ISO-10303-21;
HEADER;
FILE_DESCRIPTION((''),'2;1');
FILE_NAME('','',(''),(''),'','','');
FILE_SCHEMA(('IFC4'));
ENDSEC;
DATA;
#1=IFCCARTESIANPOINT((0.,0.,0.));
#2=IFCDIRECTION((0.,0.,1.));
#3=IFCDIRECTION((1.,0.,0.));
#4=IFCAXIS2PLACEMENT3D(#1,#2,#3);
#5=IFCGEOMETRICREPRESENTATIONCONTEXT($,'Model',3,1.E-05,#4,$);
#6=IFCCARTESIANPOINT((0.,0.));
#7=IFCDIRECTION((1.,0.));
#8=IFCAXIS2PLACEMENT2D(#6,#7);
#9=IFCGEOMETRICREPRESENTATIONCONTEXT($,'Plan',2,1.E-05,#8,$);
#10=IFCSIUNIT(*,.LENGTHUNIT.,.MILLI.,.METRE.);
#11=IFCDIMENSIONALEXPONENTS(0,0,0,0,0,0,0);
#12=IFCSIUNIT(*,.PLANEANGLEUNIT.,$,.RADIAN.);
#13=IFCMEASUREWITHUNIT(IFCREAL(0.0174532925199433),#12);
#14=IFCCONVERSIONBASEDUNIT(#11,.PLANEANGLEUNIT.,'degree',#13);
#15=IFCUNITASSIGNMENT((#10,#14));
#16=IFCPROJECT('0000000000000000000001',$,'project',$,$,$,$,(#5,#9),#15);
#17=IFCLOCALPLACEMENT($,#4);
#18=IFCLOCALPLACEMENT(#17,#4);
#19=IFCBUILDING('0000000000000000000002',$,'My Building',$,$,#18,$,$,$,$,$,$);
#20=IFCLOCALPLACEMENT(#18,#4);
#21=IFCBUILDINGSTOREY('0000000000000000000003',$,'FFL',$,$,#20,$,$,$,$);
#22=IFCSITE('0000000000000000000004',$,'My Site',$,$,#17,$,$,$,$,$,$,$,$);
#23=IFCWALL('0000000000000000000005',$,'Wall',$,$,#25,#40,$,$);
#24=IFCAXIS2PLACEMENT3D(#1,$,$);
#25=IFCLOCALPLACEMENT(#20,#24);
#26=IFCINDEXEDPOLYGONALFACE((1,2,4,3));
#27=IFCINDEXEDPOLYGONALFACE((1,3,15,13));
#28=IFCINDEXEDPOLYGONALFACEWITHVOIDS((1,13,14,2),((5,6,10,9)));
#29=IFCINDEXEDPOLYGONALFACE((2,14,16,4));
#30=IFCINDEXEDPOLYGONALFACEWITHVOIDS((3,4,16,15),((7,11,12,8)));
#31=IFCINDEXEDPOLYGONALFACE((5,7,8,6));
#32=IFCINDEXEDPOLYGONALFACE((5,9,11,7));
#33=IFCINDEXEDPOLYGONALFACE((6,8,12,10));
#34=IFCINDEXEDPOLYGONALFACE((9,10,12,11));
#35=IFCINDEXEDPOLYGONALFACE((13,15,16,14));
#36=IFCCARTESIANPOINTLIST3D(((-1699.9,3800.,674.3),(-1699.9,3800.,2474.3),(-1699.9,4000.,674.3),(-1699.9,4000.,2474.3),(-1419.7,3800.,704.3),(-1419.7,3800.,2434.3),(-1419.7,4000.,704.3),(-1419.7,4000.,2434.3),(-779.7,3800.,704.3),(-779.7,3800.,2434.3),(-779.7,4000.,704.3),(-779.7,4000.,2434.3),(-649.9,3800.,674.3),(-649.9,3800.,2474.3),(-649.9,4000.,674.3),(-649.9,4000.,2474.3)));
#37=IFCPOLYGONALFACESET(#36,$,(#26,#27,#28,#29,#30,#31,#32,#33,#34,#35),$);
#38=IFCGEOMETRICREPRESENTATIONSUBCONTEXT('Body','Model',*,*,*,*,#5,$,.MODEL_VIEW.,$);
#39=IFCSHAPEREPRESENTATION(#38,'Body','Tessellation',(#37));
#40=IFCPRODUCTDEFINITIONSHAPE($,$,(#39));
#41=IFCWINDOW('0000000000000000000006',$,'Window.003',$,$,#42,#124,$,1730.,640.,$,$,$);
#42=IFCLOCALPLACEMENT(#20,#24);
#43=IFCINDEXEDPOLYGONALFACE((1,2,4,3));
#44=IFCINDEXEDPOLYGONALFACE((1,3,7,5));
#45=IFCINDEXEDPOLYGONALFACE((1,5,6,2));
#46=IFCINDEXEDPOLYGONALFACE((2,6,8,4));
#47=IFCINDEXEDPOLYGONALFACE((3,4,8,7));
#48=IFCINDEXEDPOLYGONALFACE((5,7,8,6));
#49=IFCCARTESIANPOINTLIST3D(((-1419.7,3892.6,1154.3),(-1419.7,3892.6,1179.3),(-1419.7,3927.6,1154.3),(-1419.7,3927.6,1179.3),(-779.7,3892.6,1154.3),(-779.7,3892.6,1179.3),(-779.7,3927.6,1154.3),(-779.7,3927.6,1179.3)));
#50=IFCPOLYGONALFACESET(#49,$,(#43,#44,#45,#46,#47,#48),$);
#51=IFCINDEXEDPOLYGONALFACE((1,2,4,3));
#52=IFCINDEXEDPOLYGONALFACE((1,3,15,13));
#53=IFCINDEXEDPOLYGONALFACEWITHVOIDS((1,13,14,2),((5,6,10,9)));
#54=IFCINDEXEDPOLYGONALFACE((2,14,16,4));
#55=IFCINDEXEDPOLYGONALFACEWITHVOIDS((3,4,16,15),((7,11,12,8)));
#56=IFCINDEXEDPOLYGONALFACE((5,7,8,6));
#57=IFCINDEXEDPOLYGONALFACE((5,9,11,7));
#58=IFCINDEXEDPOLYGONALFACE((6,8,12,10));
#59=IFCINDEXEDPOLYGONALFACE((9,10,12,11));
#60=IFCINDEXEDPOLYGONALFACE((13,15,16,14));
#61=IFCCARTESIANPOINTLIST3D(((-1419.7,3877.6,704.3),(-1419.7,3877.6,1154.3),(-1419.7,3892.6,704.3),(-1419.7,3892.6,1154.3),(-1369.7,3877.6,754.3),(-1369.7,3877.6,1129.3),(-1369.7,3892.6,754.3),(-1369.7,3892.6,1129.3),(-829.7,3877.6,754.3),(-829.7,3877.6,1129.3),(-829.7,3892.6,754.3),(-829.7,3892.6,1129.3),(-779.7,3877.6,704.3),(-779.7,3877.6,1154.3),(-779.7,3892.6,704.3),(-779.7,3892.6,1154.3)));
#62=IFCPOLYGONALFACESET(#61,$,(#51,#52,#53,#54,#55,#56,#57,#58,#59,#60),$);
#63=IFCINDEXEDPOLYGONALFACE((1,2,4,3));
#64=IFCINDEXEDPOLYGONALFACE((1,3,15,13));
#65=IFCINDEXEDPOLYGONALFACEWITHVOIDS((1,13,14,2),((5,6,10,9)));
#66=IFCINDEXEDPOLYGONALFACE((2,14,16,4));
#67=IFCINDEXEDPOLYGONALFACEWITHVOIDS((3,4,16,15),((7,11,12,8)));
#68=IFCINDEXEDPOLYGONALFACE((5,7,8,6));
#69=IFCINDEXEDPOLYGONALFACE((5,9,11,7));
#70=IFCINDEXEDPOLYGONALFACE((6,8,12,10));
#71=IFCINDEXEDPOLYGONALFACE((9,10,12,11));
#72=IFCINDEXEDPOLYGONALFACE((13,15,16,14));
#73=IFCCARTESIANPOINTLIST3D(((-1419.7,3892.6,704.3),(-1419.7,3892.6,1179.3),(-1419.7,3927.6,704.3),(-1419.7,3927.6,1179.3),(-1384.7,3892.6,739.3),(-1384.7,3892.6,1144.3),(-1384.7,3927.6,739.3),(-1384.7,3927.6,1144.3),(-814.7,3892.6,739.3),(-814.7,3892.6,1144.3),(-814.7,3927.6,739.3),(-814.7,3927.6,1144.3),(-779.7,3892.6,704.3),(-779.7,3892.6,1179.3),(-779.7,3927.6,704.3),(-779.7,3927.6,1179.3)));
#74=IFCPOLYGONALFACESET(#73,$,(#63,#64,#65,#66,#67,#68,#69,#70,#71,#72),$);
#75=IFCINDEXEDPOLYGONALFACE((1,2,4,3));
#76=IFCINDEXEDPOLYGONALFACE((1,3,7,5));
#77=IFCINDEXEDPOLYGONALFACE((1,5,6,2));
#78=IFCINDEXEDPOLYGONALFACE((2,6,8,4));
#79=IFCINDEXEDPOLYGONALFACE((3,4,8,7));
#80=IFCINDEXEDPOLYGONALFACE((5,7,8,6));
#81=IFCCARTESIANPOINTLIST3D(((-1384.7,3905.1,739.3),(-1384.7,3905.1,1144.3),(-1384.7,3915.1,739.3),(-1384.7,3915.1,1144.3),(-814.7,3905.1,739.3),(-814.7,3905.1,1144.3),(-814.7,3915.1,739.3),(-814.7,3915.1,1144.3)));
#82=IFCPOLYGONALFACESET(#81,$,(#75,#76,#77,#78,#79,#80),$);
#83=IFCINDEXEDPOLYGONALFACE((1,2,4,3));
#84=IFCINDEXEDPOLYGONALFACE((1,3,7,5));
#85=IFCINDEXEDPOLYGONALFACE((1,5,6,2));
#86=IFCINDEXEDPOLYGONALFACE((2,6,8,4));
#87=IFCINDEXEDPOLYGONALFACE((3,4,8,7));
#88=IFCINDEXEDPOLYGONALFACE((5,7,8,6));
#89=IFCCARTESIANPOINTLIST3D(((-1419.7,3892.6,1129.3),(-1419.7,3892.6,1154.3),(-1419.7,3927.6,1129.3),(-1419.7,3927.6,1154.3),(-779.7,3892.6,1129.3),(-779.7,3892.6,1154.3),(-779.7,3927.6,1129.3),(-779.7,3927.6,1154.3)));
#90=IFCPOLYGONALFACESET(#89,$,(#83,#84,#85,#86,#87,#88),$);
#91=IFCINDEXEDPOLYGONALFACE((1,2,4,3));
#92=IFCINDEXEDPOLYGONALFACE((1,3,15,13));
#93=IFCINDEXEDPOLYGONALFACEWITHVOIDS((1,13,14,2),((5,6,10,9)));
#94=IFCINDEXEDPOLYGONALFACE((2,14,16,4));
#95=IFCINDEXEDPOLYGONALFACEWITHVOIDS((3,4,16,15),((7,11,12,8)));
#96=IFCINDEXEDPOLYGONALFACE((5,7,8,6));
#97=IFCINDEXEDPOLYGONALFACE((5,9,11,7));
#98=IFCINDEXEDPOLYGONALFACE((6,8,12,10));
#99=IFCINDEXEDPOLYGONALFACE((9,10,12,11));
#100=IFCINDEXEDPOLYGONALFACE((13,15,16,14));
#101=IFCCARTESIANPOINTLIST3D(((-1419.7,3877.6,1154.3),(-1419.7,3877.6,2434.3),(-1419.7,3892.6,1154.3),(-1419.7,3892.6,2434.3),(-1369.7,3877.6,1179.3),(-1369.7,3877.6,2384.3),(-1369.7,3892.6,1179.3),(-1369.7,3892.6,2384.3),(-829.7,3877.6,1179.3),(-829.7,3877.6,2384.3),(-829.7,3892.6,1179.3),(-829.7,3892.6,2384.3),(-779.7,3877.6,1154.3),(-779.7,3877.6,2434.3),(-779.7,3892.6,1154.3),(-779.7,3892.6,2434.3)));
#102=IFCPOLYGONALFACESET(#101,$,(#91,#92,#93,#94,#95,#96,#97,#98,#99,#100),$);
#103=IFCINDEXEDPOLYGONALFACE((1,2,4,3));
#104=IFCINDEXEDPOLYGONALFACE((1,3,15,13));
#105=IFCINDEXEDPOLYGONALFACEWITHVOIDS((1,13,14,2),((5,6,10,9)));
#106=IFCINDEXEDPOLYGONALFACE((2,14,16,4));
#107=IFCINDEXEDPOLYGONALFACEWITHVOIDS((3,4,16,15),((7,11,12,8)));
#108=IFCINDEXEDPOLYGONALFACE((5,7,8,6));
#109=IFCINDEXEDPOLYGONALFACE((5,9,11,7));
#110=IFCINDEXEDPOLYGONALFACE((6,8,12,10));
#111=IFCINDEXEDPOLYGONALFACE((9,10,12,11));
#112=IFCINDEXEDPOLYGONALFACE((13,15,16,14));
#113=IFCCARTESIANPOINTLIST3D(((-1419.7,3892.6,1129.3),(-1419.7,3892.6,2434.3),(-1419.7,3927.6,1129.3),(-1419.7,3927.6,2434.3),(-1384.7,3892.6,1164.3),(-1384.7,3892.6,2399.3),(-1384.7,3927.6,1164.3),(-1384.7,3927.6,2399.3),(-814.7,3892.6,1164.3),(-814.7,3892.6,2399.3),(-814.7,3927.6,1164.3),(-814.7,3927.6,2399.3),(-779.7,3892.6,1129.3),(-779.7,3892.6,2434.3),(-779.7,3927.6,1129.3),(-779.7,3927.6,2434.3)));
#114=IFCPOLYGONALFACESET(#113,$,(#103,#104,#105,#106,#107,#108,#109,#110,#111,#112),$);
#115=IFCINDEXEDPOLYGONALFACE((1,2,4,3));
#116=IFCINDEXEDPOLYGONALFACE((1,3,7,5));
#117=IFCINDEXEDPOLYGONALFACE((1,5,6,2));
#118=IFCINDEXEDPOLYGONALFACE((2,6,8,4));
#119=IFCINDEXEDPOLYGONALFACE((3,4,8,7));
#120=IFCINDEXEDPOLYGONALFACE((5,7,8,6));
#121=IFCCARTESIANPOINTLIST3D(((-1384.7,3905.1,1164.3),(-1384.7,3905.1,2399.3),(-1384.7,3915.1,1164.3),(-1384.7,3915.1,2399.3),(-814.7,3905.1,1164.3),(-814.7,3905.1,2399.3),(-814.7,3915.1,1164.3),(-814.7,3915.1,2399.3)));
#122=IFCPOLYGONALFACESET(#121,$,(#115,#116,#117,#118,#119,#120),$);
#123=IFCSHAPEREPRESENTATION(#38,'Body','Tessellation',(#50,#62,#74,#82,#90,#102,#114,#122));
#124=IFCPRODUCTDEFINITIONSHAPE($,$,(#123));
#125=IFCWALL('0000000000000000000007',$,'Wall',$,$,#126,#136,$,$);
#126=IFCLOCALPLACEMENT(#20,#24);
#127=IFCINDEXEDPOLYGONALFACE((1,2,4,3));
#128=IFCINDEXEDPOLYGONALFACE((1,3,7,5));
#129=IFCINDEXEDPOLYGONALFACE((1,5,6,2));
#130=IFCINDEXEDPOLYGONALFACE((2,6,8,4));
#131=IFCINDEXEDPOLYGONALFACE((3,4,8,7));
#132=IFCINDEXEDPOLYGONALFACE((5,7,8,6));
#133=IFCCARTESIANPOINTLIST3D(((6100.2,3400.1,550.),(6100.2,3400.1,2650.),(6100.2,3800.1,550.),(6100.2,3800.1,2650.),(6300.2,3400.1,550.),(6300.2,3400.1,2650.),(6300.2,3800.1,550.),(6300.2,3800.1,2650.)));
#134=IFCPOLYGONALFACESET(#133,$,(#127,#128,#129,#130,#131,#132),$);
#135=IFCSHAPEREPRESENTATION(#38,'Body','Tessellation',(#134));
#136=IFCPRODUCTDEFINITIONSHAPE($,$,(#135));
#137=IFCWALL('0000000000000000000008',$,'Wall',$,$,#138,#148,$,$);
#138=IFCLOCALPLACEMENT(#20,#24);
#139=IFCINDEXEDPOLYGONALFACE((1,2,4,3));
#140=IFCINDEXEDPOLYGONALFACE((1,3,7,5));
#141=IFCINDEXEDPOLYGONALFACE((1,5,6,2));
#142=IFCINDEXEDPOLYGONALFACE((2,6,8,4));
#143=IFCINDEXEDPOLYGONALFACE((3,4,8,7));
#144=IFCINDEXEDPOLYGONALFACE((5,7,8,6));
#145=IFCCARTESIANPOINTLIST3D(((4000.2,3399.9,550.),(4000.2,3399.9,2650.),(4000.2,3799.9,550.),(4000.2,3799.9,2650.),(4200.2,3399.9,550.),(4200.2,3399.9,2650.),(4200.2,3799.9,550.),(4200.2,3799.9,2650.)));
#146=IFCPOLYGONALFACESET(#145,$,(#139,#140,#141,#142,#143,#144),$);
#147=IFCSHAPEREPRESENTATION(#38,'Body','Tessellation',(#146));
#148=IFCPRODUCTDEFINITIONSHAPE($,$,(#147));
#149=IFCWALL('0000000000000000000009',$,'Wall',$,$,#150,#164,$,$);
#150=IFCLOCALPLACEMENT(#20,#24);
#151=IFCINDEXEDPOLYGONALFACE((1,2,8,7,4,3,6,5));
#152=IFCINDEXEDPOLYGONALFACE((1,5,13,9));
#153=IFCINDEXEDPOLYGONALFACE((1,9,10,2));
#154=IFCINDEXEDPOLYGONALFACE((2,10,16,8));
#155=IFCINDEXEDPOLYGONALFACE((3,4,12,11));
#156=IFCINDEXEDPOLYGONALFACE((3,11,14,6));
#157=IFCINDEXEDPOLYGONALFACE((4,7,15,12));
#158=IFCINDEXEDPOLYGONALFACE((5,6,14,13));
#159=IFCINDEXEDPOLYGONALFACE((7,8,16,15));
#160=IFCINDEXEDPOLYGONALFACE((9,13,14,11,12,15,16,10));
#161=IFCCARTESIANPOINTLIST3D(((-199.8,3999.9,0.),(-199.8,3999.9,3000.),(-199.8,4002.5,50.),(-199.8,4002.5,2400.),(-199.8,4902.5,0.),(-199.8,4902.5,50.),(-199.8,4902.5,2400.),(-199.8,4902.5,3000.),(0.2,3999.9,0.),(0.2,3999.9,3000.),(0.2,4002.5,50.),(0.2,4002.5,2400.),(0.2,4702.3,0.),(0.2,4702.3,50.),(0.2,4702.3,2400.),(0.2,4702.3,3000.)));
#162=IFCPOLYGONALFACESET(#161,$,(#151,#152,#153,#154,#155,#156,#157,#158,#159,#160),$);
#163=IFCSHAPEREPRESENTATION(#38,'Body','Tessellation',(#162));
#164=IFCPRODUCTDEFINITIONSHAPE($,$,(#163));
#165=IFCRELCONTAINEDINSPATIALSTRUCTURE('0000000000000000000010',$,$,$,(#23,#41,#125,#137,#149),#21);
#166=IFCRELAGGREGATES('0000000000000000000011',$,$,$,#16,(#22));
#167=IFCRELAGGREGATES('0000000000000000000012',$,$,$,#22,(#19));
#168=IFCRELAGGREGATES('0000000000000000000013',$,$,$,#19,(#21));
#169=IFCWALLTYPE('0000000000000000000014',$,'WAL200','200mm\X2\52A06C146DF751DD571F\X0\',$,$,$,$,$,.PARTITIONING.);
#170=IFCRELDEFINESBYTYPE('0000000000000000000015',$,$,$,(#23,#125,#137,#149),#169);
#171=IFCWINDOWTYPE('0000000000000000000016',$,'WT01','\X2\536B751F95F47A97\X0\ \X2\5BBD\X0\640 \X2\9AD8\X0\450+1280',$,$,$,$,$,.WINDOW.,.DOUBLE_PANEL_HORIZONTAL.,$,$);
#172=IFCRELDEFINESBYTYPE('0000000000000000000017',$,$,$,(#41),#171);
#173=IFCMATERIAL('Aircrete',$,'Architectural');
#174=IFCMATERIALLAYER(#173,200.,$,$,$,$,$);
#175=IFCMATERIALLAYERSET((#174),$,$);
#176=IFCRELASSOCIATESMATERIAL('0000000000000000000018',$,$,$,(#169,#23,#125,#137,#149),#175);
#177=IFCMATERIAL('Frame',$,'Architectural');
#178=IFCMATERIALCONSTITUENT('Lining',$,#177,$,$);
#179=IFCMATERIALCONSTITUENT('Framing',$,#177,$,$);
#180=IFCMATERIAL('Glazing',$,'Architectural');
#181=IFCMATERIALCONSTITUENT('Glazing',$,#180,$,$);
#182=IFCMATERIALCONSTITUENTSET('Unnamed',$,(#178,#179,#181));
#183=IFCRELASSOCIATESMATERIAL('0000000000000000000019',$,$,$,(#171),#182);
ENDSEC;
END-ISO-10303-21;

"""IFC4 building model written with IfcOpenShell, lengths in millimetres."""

from ifc_helpers import new_model, entity, si_unit, converted_unit, frame, origin_with_axes, origin_2d_with_axis, place, context, subcontext, project, spatial, line, indexed_curve, outline, extrude, shape, source, transform, mapped, material, layer, layer_set, layer_usage, constituent, constituent_set, type_object, type_shapes, element, fill, save


model = new_model("IFC4")

# Units and contexts
model_context = context("Model", 3, precision=1e-05, world=origin_with_axes())
plan_context = context("Plan", 2, precision=1e-05, world=origin_2d_with_axis())
body_context_1 = subcontext(model_context, "Body", "Model", "MODEL_VIEW")
body_context_2 = subcontext(plan_context, "Body", "Plan", "PLAN_VIEW")
ifc_project = project(units=[si_unit("LENGTHUNIT", "METRE", prefix="MILLI"), converted_unit("PLANEANGLEUNIT", "degree", entity("IfcReal", 0.0174532925199433), si_unit("PLANEANGLEUNIT", "RADIAN"), dimensions=[0, 0, 0, 0, 0, 0, 0])], contexts=[model_context, plan_context])

# Site, building, storey
site_placement = place(None, origin_with_axes())
site = spatial("IfcSite", under=ifc_project, at=site_placement, Name="My Site")
building_placement = place(site_placement, origin_with_axes())
building = spatial("IfcBuilding", under=site, at=building_placement, Name="My Building")
storey_placement = place(building_placement, origin_with_axes())
storey = spatial("IfcBuildingStorey", under=building, at=storey_placement, Name="FFL")

# Shared definitions
ifc_material_1 = material(Name="Aircrete", Category="Architectural")

# Shared definitions
ifc_material_2 = material(Name="Frame", Category="Architectural")

# Shared definitions
ifc_layer_1 = layer(ifc_material_1, 200.0)
ifc_layer_set_1 = layer_set([ifc_layer_1])
wall_type_1 = type_object("IfcWallType", Name="WAL200", Description="200mm加气混凝土", PredefinedType="PARTITIONING", material=ifc_layer_set_1)
ifc_material_3 = material(Name="Glazing", Category="Architectural")

# Wall, opening, window
ifc_layer_usage_1 = layer_usage(ifc_layer_set_1, "AXIS2", "NEGATIVE", 0.0)
wall_1_placement = place(storey_placement, frame((-1699.9, 4000.0, 674.3), z_axis=(0.0, 0.0, 1.0), x_axis=(1.0, 0.0, 0.0)))
wall_1 = element("IfcWall", 1, at=wall_1_placement, inside=storey, type_object=wall_type_1, material=ifc_layer_usage_1, Name="Wall", context=body_context_1, shape_type="SweptSolid", body=[
    extrude(outline(indexed_curve([(0.0, -200.0), (0.0, 0.0), (1050.0, 0.0), (1050.0, -200.0)], segments=[line(1, 2, 3, 4, 1)])), origin_with_axes(), (0.0, 0.0, 1.0), 1800.0),
])
shared_shape_1 = source(origin_with_axes(), body_context_1, "Body", "SweptSolid", [
    extrude(outline(indexed_curve([(0.0, 0.0), (640.0, 0.0), (640.0, 1730.0), (0.0, 1730.0)], segments=[line(1, 2, 3, 4, 1)])), frame((0.0, -600.0, 0.0), z_axis=(0.0, -1.0, 0.0), x_axis=(1.0, 0.0, 0.0)), (0.0, 0.0, -1.0), 1200.0),
])
opening_1_placement = place(wall_1_placement, frame((280.2, -172.4, 30.0), z_axis=(0.0, 0.0, 1.0), x_axis=(1.0, 0.0, 0.0)))
opening_1 = element("IfcOpeningElement", 2, at=opening_1_placement, cuts=wall_1, PredefinedType="OPENING", context=body_context_1, shape_type="MappedRepresentation", body=[
    mapped(shared_shape_1, transform((0.0, 0.0, 0.0), x_axis=(1.0, 0.0, 0.0), y_axis=(0.0, 1.0, 0.0), z_axis=(0.0, 0.0, 1.0), scale=1.0)),
])
ifc_constituent_1 = constituent(ifc_material_2, Name="Lining")
ifc_constituent_2 = constituent(ifc_material_2, Name="Framing")
ifc_constituent_3 = constituent(ifc_material_3, Name="Glazing")
ifc_constituent_set_1 = constituent_set(constituents=[ifc_constituent_1, ifc_constituent_2, ifc_constituent_3], Name="Unnamed")
window_type_1 = type_object("IfcWindowType", Name="WT01", Description="卫生间窗 宽640 高450+1280", PartitioningType="DOUBLE_PANEL_HORIZONTAL", PredefinedType="WINDOW", material=ifc_constituent_set_1)
shared_shape_2 = source(origin_with_axes(), body_context_1, "Body", "SweptSolid", [
    extrude(outline(indexed_curve([(0.0, 450.0), (640.0, 450.0), (640.0, 475.0), (0.0, 475.0)], segments=[line(1, 2, 3, 4, 1)])), frame((0.0, 65.0, 0.0), z_axis=(0.0, -1.0, 0.0), x_axis=(1.0, 0.0, 0.0)), (0.0, 0.0, -1.0), 35.0),
    extrude(outline(indexed_curve([(0.0, 0.0), (640.0, 0.0), (640.0, 450.0), (0.0, 450.0)], segments=[line(1, 2, 3, 4, 1)]), holes=[indexed_curve([(50.0, 50.0), (590.0, 50.0), (590.0, 425.0), (50.0, 425.0)], segments=[line(1, 2, 3, 4, 1)])]), frame((0.0, 50.0, 0.0), z_axis=(0.0, -1.0, 0.0), x_axis=(1.0, 0.0, 0.0)), (0.0, 0.0, -1.0), 15.0),
    extrude(outline(indexed_curve([(0.0, 0.0), (640.0, 0.0), (640.0, 475.0), (0.0, 475.0)], segments=[line(1, 2, 3, 4, 1)]), holes=[indexed_curve([(35.0, 35.0), (605.0, 35.0), (605.0, 440.0), (35.0, 440.0)], segments=[line(1, 2, 3, 4, 1)])]), frame((0.0, 65.0, 0.0), z_axis=(0.0, -1.0, 0.0), x_axis=(1.0, 0.0, 0.0)), (0.0, 0.0, -1.0), 35.0),
    extrude(outline(indexed_curve([(35.0, 35.0), (605.0, 35.0), (605.0, 440.0), (35.0, 440.0)], segments=[line(1, 2, 3, 4, 1)])), frame((0.0, 77.5, 0.0), z_axis=(0.0, -1.0, 0.0), x_axis=(1.0, 0.0, 0.0)), (0.0, 0.0, -1.0), 10.0),
    extrude(outline(indexed_curve([(640.0, 0.0), (0.0, 0.0), (0.0, -25.0), (640.0, -25.0)], segments=[line(1, 2, 3, 4, 1)])), frame((0.0, 65.0, 450.0), z_axis=(0.0, -1.0, 0.0), x_axis=(1.0, 0.0, 0.0)), (0.0, 0.0, -1.0), 35.0),
    extrude(outline(indexed_curve([(0.0, 0.0), (640.0, 0.0), (640.0, 1280.0), (0.0, 1280.0)], segments=[line(1, 2, 3, 4, 1)]), holes=[indexed_curve([(50.0, 25.0), (590.0, 25.0), (590.0, 1230.0), (50.0, 1230.0)], segments=[line(1, 2, 3, 4, 1)])]), frame((0.0, 50.0, 450.0), z_axis=(0.0, -1.0, 0.0), x_axis=(1.0, 0.0, 0.0)), (0.0, 0.0, -1.0), 15.0),
    extrude(outline(indexed_curve([(0.0, 0.0), (640.0, 0.0), (640.0, 1305.0), (0.0, 1305.0)], segments=[line(1, 2, 3, 4, 1)]), holes=[indexed_curve([(35.0, 35.0), (605.0, 35.0), (605.0, 1270.0), (35.0, 1270.0)], segments=[line(1, 2, 3, 4, 1)])]), frame((0.0, 65.0, 425.0), z_axis=(0.0, -1.0, 0.0), x_axis=(1.0, 0.0, 0.0)), (0.0, 0.0, -1.0), 35.0),
    extrude(outline(indexed_curve([(35.0, 35.0), (605.0, 35.0), (605.0, 1270.0), (35.0, 1270.0)], segments=[line(1, 2, 3, 4, 1)])), frame((0.0, 77.5, 425.0), z_axis=(0.0, -1.0, 0.0), x_axis=(1.0, 0.0, 0.0)), (0.0, 0.0, -1.0), 10.0),
])
shared_shape_3 = source(origin_with_axes(), body_context_2, "Body", "Curve2D", [
    entity("IfcIndexedPolyCurve", entity("IfcCartesianPointList2D", [[50.0, 50.0], [590.0, 50.0]])),
    entity("IfcIndexedPolyCurve", entity("IfcCartesianPointList2D", [[0.0, 100.0], [0.0, 100.0], [0.0, 65.0], [50.0, 65.0], [50.0, 50.0], [0.0, 50.0]]), [entity("IfcLineIndex", [1, 2, 3, 4, 5, 6, 1])]),
    entity("IfcIndexedPolyCurve", entity("IfcCartesianPointList2D", [[640.0, 100.0], [640.0, 100.0], [640.0, 65.0], [590.0, 65.0], [590.0, 50.0], [640.0, 50.0]]), [entity("IfcLineIndex", [1, 2, 3, 4, 5, 6, 1])]),
    entity("IfcIndexedPolyCurve", entity("IfcCartesianPointList2D", [[0.0, 65.0], [35.0, 65.0], [35.0, 100.0], [0.0, 100.0]]), [entity("IfcLineIndex", [1, 2, 3, 4, 1])]),
    entity("IfcIndexedPolyCurve", entity("IfcCartesianPointList2D", [[640.0, 65.0], [605.0, 65.0], [605.0, 100.0], [640.0, 100.0]]), [entity("IfcLineIndex", [1, 2, 3, 4, 1])]),
    entity("IfcIndexedPolyCurve", entity("IfcCartesianPointList2D", [[35.0, 65.0], [605.0, 65.0]])),
    entity("IfcIndexedPolyCurve", entity("IfcCartesianPointList2D", [[35.0, 100.0], [605.0, 100.0]])),
    entity("IfcIndexedPolyCurve", entity("IfcCartesianPointList2D", [[35.0, 82.5], [605.0, 82.5]])),
])
type_shapes(window_type_1, [shared_shape_2, shared_shape_3])
window_1_placement = place(opening_1_placement, origin_with_axes())
window_1 = element("IfcWindow", 3, at=window_1_placement, inside=storey, type_object=window_type_1, Name="Window.003", OverallHeight=1730.0, OverallWidth=640.0, shapes=[
    shape(body_context_1, "Body", "MappedRepresentation", [mapped(shared_shape_2, transform((0.0, 0.0, 0.0), x_axis=(1.0, 0.0, 0.0), y_axis=(0.0, 1.0, 0.0), z_axis=(0.0, 0.0, 1.0), scale=1.0))]),
    shape(body_context_2, "Body", "MappedRepresentation", [mapped(shared_shape_3, transform((0.0, 0.0, 0.0), x_axis=(1.0, 0.0, 0.0), y_axis=(0.0, 1.0, 0.0), z_axis=(0.0, 0.0, 1.0), scale=1.0))]),
])
fill(opening_1, window_1)

# Walls
ifc_layer_usage_2 = layer_usage(ifc_layer_set_1, "AXIS2", "NEGATIVE", 0.0)
wall_2_placement = place(storey_placement, frame((6100.2, 3400.1, 550.0), z_axis=(0.0, 0.0, 1.0), x_axis=(0.0, 1.0, 0.0)))
element("IfcWall", 4, at=wall_2_placement, inside=storey, type_object=wall_type_1, material=ifc_layer_usage_2, Name="Wall", context=body_context_1, shape_type="SweptSolid", body=[
    extrude(outline(indexed_curve([(0.0, -200.0), (0.0, 0.0), (400.0, 0.0), (400.0, -200.0)], segments=[line(1, 2, 3, 4, 1)])), origin_with_axes(), (0.0, 0.0, 1.0), 2100.0),
])
ifc_layer_usage_3 = layer_usage(ifc_layer_set_1, "AXIS2", "NEGATIVE", 0.0)
wall_3_placement = place(storey_placement, frame((4200.2, 3799.9, 550.0), z_axis=(0.0, 0.0, 1.0), x_axis=(0.0, -1.0, 0.0)))
element("IfcWall", 5, at=wall_3_placement, inside=storey, type_object=wall_type_1, material=ifc_layer_usage_3, Name="Wall", context=body_context_1, shape_type="SweptSolid", body=[
    extrude(outline(indexed_curve([(0.0, -200.0), (0.0, 0.0), (400.0, 0.0), (400.0, -200.0)], segments=[line(1, 2, 3, 4, 1)])), origin_with_axes(), (0.0, 0.0, 1.0), 2100.0),
])

# Wall, opening
ifc_layer_usage_4 = layer_usage(ifc_layer_set_1, "AXIS2", "NEGATIVE", 0.0)
wall_4_placement = place(storey_placement, frame((-199.8, 3999.9, 0.0), z_axis=(0.0, 0.0, 1.0), x_axis=(0.000001, 1.0, 0.0)))
wall_4 = element("IfcWall", 6, at=wall_4_placement, inside=storey, type_object=wall_type_1, material=ifc_layer_usage_4, Name="Wall", context=body_context_1, shape_type="SweptSolid", body=[
    extrude(outline(indexed_curve([(0.0, -200.0), (0.0, 0.0), (902.5, 0.0), (702.4, -200.0)], segments=[line(1, 2, 3, 4, 1)])), origin_with_axes(), (0.0, 0.0, 1.0), 3000.0),
])
opening_2_placement = place(wall_4_placement, frame((2.6, 200.0, 50.0), z_axis=(0.0, 0.0, 1.0), x_axis=(0.0, -1.0, 0.0)))
element("IfcOpeningElement", 7, at=opening_2_placement, cuts=wall_4, PredefinedType="OPENING", context=body_context_1, shape_type="SweptSolid", body=[
    extrude(outline(indexed_curve([(0.0, 0.0), (4600.0, 0.0), (4600.0, 1146.7), (0.0, 1146.7), (0.0, 0.0)])), origin_with_axes(), (0.0, 0.0, 1.0), 2350.0),
])

save(model, "model.ifc")
